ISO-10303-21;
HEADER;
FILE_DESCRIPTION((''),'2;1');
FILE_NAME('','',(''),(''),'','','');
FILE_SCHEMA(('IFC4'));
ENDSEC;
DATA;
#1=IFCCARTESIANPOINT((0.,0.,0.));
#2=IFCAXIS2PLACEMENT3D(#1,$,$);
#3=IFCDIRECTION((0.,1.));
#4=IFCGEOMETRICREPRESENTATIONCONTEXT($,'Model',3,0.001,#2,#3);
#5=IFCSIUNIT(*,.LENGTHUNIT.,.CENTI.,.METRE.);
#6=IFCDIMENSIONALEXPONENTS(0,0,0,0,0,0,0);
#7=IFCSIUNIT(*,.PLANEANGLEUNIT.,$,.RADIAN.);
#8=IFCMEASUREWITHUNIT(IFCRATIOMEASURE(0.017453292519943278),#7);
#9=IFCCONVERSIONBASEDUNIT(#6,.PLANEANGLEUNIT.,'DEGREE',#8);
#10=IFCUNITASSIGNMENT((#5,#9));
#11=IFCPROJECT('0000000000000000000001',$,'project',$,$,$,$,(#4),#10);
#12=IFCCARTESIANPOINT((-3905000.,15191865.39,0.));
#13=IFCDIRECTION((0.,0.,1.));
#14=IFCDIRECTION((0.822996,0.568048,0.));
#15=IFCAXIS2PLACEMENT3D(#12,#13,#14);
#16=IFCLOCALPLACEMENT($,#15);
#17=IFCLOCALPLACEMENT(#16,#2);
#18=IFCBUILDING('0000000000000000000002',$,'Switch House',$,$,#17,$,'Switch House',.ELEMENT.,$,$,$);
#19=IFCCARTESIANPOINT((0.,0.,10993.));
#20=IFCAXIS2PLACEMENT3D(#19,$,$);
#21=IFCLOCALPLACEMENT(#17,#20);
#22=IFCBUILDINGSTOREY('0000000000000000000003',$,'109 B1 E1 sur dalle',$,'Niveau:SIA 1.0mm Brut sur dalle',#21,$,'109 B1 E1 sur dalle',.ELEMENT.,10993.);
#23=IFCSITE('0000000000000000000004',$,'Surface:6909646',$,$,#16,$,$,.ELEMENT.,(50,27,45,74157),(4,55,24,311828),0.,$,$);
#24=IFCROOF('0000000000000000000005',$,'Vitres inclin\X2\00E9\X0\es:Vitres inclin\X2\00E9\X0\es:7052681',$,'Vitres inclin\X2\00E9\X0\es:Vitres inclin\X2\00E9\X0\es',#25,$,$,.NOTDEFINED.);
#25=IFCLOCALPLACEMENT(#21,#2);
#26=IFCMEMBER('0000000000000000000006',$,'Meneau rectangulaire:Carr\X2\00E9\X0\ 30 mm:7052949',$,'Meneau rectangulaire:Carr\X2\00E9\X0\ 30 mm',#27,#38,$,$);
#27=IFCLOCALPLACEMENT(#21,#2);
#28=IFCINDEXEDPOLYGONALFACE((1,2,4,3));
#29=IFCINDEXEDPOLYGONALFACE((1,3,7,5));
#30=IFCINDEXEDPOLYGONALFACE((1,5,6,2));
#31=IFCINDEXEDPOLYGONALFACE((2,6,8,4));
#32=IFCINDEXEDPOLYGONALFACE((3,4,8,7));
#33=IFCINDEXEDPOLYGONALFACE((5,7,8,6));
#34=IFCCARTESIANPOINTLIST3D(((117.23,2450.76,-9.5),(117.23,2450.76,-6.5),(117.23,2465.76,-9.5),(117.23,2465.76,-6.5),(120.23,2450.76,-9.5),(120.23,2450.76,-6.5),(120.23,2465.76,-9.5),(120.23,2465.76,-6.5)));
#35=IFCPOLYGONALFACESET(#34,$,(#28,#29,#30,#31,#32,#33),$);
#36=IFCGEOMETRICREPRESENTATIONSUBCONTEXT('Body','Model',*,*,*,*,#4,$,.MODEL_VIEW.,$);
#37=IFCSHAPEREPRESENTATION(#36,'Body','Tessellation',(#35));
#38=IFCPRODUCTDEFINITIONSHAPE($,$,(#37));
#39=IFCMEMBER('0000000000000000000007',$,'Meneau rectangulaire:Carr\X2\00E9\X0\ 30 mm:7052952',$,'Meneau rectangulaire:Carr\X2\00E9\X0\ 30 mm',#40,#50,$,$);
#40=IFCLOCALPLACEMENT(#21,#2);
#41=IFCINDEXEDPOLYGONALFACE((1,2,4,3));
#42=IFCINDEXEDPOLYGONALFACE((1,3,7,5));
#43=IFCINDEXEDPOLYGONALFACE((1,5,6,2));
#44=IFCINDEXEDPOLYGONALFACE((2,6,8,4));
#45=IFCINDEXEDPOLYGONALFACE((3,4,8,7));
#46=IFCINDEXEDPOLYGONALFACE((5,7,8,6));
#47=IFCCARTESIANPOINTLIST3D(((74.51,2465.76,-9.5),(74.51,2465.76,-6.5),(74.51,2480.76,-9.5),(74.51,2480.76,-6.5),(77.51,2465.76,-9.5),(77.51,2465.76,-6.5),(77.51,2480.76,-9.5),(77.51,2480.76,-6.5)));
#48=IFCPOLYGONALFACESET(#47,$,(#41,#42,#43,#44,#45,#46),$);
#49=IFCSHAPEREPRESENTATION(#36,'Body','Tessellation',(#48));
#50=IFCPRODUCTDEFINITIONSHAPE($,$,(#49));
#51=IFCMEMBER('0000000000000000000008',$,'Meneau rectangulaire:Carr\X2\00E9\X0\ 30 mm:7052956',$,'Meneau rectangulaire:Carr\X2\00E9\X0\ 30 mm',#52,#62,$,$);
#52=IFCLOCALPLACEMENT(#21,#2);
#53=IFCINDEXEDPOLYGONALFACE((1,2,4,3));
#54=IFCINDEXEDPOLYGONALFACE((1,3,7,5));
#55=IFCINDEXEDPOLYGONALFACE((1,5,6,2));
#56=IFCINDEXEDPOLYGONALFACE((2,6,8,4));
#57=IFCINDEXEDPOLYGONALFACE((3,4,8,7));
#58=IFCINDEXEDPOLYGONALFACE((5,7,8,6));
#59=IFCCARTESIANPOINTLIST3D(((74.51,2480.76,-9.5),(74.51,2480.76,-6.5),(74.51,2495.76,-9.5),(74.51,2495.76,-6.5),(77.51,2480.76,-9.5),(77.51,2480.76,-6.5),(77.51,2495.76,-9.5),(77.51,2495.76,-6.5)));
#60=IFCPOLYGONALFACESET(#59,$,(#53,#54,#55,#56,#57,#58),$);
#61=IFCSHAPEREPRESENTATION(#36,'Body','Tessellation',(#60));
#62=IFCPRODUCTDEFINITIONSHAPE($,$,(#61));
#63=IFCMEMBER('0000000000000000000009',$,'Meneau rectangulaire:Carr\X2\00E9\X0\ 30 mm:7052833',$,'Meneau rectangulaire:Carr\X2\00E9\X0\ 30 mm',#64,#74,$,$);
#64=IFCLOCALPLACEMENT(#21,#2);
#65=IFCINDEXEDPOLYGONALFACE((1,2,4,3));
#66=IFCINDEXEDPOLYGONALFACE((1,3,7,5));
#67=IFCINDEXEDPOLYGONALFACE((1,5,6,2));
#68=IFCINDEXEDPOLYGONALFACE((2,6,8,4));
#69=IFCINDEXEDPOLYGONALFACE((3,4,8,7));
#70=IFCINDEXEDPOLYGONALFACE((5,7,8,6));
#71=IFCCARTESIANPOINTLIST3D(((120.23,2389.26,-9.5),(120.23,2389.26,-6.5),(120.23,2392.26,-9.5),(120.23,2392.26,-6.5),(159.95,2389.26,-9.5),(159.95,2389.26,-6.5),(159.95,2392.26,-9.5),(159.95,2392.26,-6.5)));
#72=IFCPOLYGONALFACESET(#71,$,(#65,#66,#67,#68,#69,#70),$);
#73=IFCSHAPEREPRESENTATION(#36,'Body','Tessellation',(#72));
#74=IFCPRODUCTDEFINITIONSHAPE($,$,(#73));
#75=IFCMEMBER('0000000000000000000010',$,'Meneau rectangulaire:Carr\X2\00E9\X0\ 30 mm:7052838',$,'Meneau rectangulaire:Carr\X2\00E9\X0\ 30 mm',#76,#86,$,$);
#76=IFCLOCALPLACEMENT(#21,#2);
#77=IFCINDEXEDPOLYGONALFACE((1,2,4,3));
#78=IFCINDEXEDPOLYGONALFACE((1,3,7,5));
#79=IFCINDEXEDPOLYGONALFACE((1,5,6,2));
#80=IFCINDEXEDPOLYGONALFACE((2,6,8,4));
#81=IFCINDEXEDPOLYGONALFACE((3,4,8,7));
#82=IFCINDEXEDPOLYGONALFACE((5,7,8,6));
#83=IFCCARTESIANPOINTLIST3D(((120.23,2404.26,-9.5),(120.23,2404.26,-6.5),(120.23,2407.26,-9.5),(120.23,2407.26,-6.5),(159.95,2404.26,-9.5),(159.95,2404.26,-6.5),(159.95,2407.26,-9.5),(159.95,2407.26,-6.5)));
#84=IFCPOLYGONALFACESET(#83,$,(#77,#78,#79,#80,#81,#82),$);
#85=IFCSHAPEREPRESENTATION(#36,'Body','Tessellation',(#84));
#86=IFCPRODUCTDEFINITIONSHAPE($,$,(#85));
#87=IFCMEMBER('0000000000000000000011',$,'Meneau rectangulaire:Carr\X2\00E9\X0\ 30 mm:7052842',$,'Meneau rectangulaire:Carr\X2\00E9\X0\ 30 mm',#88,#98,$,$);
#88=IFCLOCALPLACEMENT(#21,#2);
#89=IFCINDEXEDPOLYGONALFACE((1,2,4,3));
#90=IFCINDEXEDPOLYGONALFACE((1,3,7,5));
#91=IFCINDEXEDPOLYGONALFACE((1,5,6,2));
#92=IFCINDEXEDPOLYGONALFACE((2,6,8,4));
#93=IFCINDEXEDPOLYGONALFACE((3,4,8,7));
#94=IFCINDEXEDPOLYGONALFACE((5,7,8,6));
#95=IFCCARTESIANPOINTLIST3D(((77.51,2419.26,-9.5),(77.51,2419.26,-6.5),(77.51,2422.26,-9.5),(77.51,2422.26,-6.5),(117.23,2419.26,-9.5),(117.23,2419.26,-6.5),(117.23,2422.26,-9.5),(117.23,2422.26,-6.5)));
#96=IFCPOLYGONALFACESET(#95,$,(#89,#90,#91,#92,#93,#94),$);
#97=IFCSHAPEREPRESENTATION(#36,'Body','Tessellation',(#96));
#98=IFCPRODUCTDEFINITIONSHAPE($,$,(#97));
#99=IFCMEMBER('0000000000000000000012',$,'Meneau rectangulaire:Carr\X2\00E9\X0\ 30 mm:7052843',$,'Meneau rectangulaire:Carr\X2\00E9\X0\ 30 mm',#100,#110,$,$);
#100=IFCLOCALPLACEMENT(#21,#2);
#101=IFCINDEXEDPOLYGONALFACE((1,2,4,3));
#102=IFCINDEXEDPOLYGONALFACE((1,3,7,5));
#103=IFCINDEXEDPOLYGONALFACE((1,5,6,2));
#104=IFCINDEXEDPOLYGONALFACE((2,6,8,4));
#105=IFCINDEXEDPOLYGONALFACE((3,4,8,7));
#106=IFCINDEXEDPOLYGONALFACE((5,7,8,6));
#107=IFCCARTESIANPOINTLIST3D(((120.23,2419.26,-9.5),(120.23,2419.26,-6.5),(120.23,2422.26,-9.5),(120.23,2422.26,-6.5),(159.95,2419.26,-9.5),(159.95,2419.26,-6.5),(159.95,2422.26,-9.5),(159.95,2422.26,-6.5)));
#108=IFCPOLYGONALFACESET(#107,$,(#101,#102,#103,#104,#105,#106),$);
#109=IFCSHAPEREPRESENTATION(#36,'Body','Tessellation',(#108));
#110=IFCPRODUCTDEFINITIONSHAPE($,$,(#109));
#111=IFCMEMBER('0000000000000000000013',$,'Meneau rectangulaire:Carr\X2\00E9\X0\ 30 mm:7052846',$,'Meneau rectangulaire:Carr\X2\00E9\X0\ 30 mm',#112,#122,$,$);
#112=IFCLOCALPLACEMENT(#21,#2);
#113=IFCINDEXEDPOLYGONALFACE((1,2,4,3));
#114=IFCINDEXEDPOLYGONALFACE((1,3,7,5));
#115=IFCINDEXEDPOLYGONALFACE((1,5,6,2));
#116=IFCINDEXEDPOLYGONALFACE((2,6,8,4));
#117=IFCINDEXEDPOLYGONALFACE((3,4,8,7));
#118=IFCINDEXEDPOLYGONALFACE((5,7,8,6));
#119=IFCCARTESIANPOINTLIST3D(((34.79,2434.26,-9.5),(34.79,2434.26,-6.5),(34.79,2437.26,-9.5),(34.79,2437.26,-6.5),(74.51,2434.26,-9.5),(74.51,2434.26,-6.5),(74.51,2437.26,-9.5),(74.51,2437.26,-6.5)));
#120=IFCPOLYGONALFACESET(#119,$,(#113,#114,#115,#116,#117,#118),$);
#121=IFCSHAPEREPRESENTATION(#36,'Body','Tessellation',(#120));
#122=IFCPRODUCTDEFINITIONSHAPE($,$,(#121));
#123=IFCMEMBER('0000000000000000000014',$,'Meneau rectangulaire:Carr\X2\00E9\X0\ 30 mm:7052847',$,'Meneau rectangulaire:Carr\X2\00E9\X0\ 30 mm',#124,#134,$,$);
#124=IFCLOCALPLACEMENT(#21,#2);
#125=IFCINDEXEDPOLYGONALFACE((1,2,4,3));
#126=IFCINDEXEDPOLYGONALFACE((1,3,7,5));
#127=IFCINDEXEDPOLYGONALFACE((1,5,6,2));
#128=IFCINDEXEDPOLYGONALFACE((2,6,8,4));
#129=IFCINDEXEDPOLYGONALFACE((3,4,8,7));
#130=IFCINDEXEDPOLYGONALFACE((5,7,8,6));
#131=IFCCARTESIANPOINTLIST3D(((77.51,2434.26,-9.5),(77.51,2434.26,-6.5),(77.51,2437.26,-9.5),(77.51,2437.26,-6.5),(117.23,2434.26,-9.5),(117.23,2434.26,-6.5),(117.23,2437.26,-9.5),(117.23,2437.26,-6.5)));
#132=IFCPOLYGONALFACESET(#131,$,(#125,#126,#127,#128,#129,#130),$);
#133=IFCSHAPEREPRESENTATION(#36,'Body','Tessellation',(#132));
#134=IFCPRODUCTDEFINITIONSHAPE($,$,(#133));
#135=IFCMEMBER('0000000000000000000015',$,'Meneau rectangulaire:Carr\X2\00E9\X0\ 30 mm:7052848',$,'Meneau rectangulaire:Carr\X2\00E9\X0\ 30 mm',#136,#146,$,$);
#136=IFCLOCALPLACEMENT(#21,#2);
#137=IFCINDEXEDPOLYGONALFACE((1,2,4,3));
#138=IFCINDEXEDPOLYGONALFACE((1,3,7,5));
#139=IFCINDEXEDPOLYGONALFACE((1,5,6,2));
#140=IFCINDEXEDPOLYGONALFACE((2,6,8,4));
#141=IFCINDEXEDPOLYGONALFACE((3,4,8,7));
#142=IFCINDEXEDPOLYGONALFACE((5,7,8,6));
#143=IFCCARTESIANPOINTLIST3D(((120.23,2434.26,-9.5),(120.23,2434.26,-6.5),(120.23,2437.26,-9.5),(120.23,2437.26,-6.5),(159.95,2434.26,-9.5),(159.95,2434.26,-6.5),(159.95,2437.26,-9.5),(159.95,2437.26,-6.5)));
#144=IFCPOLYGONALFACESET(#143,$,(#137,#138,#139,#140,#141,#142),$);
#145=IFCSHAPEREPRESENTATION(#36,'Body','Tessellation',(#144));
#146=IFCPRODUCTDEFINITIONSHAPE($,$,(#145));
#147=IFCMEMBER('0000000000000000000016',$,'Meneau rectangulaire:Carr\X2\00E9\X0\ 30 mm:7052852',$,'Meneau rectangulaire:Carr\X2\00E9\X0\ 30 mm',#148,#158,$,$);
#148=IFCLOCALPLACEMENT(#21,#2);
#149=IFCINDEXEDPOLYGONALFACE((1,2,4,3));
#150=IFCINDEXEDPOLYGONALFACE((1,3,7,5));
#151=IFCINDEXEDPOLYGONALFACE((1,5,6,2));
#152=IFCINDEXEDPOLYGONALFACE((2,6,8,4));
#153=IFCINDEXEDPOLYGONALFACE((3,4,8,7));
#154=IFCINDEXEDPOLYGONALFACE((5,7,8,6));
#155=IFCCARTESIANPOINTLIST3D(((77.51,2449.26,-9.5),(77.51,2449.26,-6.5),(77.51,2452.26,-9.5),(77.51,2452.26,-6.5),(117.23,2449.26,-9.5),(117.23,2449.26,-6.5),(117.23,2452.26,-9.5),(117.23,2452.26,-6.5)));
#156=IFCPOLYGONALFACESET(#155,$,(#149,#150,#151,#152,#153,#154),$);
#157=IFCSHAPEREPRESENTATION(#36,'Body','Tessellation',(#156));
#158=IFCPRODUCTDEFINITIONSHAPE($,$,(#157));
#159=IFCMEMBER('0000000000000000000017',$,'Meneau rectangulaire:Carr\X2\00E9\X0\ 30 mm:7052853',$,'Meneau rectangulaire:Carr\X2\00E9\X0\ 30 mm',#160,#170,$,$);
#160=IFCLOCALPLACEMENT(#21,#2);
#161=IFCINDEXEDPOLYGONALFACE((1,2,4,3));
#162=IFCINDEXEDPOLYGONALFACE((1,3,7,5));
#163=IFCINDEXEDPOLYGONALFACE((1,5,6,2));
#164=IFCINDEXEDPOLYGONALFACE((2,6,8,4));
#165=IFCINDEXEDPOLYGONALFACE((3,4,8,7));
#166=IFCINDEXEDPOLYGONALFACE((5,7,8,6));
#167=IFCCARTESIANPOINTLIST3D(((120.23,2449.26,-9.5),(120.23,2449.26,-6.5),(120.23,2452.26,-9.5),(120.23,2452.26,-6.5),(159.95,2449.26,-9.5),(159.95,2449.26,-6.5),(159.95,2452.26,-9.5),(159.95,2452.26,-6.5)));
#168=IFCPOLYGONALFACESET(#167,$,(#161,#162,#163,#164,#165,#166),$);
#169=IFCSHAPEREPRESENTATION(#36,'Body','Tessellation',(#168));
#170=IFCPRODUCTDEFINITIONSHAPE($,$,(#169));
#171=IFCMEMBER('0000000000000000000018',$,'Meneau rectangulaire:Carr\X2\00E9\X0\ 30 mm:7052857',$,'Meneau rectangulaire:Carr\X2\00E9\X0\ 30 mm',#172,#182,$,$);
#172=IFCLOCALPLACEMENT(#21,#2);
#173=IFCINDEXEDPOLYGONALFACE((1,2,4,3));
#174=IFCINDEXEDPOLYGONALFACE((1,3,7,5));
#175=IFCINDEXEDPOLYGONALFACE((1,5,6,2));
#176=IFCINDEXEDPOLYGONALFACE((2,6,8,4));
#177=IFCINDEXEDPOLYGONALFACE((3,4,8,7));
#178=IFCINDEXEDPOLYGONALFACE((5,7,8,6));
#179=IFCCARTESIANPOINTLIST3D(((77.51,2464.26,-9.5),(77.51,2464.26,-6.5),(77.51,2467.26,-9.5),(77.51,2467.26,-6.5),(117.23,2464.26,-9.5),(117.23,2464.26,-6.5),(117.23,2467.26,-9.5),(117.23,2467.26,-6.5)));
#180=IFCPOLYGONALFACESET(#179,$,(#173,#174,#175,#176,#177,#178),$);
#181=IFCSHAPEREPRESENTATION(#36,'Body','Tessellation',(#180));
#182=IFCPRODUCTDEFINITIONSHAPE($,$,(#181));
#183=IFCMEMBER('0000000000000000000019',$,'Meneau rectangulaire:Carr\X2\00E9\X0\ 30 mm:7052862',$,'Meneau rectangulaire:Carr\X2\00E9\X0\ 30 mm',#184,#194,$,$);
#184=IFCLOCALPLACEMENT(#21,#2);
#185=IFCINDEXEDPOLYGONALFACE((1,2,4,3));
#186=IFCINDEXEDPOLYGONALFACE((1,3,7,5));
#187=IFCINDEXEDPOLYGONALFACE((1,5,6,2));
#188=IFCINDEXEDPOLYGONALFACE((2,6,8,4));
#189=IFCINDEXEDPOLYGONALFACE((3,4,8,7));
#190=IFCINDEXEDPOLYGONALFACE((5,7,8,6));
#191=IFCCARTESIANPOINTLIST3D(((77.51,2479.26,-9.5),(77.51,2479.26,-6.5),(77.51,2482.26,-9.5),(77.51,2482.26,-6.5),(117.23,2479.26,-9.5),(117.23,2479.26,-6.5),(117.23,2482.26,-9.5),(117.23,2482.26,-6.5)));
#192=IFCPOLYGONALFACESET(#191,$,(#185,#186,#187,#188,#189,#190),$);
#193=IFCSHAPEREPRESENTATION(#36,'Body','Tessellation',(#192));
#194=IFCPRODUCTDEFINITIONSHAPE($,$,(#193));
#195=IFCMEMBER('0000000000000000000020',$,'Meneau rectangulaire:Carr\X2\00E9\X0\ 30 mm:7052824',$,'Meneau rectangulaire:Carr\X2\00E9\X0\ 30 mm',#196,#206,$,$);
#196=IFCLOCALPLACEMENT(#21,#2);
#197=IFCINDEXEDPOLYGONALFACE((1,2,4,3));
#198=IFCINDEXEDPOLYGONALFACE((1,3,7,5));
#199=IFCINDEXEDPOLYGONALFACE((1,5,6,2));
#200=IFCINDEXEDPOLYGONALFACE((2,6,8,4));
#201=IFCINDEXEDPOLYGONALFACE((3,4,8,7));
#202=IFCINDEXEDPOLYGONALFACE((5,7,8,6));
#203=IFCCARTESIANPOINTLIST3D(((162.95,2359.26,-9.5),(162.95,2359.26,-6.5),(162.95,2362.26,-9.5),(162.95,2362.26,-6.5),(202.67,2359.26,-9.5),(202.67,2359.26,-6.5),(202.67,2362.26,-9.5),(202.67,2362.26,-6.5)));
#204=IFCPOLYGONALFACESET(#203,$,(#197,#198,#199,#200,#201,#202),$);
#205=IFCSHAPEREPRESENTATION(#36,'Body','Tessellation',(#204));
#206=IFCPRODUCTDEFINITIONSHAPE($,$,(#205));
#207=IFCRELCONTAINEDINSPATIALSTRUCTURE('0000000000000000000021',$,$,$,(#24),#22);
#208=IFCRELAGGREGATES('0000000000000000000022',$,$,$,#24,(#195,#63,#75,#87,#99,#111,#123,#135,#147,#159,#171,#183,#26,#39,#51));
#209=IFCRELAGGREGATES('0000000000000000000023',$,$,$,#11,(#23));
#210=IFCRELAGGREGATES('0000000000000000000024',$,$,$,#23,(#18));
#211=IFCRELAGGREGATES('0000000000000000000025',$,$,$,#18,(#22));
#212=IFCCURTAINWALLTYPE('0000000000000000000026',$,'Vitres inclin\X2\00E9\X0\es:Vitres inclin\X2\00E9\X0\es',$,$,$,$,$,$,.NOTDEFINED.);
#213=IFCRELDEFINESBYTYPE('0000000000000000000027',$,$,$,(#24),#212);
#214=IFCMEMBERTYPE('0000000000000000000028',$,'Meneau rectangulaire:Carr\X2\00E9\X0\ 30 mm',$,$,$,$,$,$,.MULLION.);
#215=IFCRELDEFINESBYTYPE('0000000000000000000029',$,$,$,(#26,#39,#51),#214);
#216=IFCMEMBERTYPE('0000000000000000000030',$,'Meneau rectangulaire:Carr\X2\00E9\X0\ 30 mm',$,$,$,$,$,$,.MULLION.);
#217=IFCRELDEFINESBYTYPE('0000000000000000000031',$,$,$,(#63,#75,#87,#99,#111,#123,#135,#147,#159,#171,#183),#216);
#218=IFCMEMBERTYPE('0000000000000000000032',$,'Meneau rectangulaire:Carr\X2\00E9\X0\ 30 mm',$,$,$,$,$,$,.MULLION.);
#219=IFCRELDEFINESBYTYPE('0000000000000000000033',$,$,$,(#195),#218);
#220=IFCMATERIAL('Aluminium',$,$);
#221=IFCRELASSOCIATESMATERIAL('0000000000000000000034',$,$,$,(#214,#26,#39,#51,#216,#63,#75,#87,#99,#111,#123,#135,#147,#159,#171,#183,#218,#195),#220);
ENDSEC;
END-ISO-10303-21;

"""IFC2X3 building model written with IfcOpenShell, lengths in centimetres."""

from ifc_helpers import new_model, entity, si_unit, converted_unit, direction, frame, origin, origin_2d_with_axis, place, context, subcontext, project, spatial, rectangle, extrude, source, transform, mapped, material, type_object, type_shapes, element, aggregate, save


model = new_model("IFC2X3")

# Units and contexts
model_context = context("Model", 3, precision=0.001, world=origin(), true_north=direction((0.0, 1.0)))
body_context = subcontext(model_context, "Body", "Model", "MODEL_VIEW")
ifc_project = project(units=[si_unit("LENGTHUNIT", "METRE", prefix="CENTI"), converted_unit("PLANEANGLEUNIT", "DEGREE", entity("IfcRatioMeasure", 0.017453292519943278), si_unit("PLANEANGLEUNIT", "RADIAN"), dimensions=[0, 0, 0, 0, 0, 0, 0])], contexts=[model_context])

# Site, building, storey
site_placement = place(None, frame((-3905000.0, 15191865.39, 0.0), z_axis=(0.0, 0.0, 1.0), x_axis=(0.822996, 0.568048, 0.0)))
site = spatial("IfcSite", under=ifc_project, at=site_placement, Name="Surface:6909646", CompositionType="ELEMENT", RefLatitude=(50, 27, 45, 74157), RefLongitude=(4, 55, 24, 311828), RefElevation=0.0)
building_placement = place(site_placement, origin())
building = spatial("IfcBuilding", under=site, at=building_placement, Name="Switch House", LongName="Switch House", CompositionType="ELEMENT")
storey_placement = place(building_placement, frame((0.0, 0.0, 10993.0)))
storey = spatial("IfcBuildingStorey", under=building, at=storey_placement, Name="109 B1 E1 sur dalle", ObjectType="Niveau:SIA 1.0mm Brut sur dalle", LongName="109 B1 E1 sur dalle", CompositionType="ELEMENT", Elevation=10993.0)

# Roof, members
curtain_wall_type = type_object("IfcCurtainWallType", Name="Vitres inclinées:Vitres inclinées", PredefinedType="NOTDEFINED")
roof_placement = place(storey_placement, frame((0.0, 0.0, -10993.0)))
roof = element("IfcRoof", 1, at=roof_placement, inside=storey, type_object=curtain_wall_type, Name="Vitres inclinées:Vitres inclinées:7052681", ObjectType="Vitres inclinées:Vitres inclinées", ShapeType="NOTDEFINED")
ifc_material = material(Name="Aluminium")
member_type_1 = type_object("IfcMemberType", Name="Meneau rectangulaire:Carré 30 mm", PredefinedType="MULLION", material=ifc_material)
shared_shape_1 = source(origin(), body_context, "Body", "SweptSolid", [
    extrude(rectangle(XDim=3.0, YDim=3.0, at=origin_2d_with_axis()), frame((0.0, 0.0, -15.0), z_axis=(0.0, 0.0, 1.0), x_axis=(0.0, -1.0, 0.0)), (0.0, 0.0, 1.0), 15.0),
])
type_shapes(member_type_1, [shared_shape_1])
member_1_placement = place(roof_placement, frame((118.73, 2465.76, 10985.0), z_axis=(0.0, 1.0, 0.0), x_axis=(1.0, 0.0, 0.0)))
member_1 = element("IfcMember", 2, at=member_1_placement, type_object=member_type_1, material=ifc_material, Name="Meneau rectangulaire:Carré 30 mm:7052949", ObjectType="Meneau rectangulaire:Carré 30 mm", context=body_context, shape_type="MappedRepresentation", body=[
    mapped(shared_shape_1, transform((0.0, 0.0, 0.0), scale=1.0)),
])
member_2_placement = place(roof_placement, frame((76.01, 2480.76, 10985.0), z_axis=(0.0, 1.0, 0.0), x_axis=(1.0, 0.0, 0.0)))
member_2 = element("IfcMember", 3, at=member_2_placement, type_object=member_type_1, material=ifc_material, Name="Meneau rectangulaire:Carré 30 mm:7052952", ObjectType="Meneau rectangulaire:Carré 30 mm", context=body_context, shape_type="MappedRepresentation", body=[
    mapped(shared_shape_1, transform((0.0, 0.0, 0.0), scale=1.0)),
])
member_3_placement = place(roof_placement, frame((76.01, 2495.76, 10985.0), z_axis=(0.0, 1.0, 0.0), x_axis=(1.0, 0.0, 0.0)))
member_3 = element("IfcMember", 4, at=member_3_placement, type_object=member_type_1, material=ifc_material, Name="Meneau rectangulaire:Carré 30 mm:7052956", ObjectType="Meneau rectangulaire:Carré 30 mm", context=body_context, shape_type="MappedRepresentation", body=[
    mapped(shared_shape_1, transform((0.0, 0.0, 0.0), scale=1.0)),
])
member_type_2 = type_object("IfcMemberType", Name="Meneau rectangulaire:Carré 30 mm", PredefinedType="MULLION", material=ifc_material)
shared_shape_2 = source(origin(), body_context, "Body", "SweptSolid", [
    extrude(rectangle(XDim=3.0, YDim=3.0, at=origin_2d_with_axis()), frame((0.0, 0.0, -39.72), z_axis=(0.0, 0.0, 1.0), x_axis=(0.0, -1.0, 0.0)), (0.0, 0.0, 1.0), 39.72),
])
type_shapes(member_type_2, [shared_shape_2])
member_4_placement = place(roof_placement, frame((120.23, 2390.76, 10985.0), z_axis=(-1.0, 0.0, 0.0), x_axis=(0.0, 1.0, 0.0)))
member_4 = element("IfcMember", 5, at=member_4_placement, type_object=member_type_2, material=ifc_material, Name="Meneau rectangulaire:Carré 30 mm:7052833", ObjectType="Meneau rectangulaire:Carré 30 mm", context=body_context, shape_type="MappedRepresentation", body=[
    mapped(shared_shape_2, transform((0.0, 0.0, 0.0), scale=1.0)),
])
member_5_placement = place(roof_placement, frame((120.23, 2405.76, 10985.0), z_axis=(-1.0, 0.0, 0.0), x_axis=(0.0, 1.0, 0.0)))
member_5 = element("IfcMember", 6, at=member_5_placement, type_object=member_type_2, material=ifc_material, Name="Meneau rectangulaire:Carré 30 mm:7052838", ObjectType="Meneau rectangulaire:Carré 30 mm", context=body_context, shape_type="MappedRepresentation", body=[
    mapped(shared_shape_2, transform((0.0, 0.0, 0.0), scale=1.0)),
])
member_6_placement = place(roof_placement, frame((77.51, 2420.76, 10985.0), z_axis=(-1.0, 0.0, 0.0), x_axis=(0.0, 1.0, 0.0)))
member_6 = element("IfcMember", 7, at=member_6_placement, type_object=member_type_2, material=ifc_material, Name="Meneau rectangulaire:Carré 30 mm:7052842", ObjectType="Meneau rectangulaire:Carré 30 mm", context=body_context, shape_type="MappedRepresentation", body=[
    mapped(shared_shape_2, transform((0.0, 0.0, 0.0), scale=1.0)),
])
member_7_placement = place(roof_placement, frame((120.23, 2420.76, 10985.0), z_axis=(-1.0, 0.0, 0.0), x_axis=(0.0, 1.0, 0.0)))
member_7 = element("IfcMember", 8, at=member_7_placement, type_object=member_type_2, material=ifc_material, Name="Meneau rectangulaire:Carré 30 mm:7052843", ObjectType="Meneau rectangulaire:Carré 30 mm", context=body_context, shape_type="MappedRepresentation", body=[
    mapped(shared_shape_2, transform((0.0, 0.0, 0.0), scale=1.0)),
])
member_8_placement = place(roof_placement, frame((34.79, 2435.76, 10985.0), z_axis=(-1.0, 0.0, 0.0), x_axis=(0.0, 1.0, 0.0)))
member_8 = element("IfcMember", 9, at=member_8_placement, type_object=member_type_2, material=ifc_material, Name="Meneau rectangulaire:Carré 30 mm:7052846", ObjectType="Meneau rectangulaire:Carré 30 mm", context=body_context, shape_type="MappedRepresentation", body=[
    mapped(shared_shape_2, transform((0.0, 0.0, 0.0), scale=1.0)),
])
member_9_placement = place(roof_placement, frame((77.51, 2435.76, 10985.0), z_axis=(-1.0, 0.0, 0.0), x_axis=(0.0, 1.0, 0.0)))
member_9 = element("IfcMember", 10, at=member_9_placement, type_object=member_type_2, material=ifc_material, Name="Meneau rectangulaire:Carré 30 mm:7052847", ObjectType="Meneau rectangulaire:Carré 30 mm", context=body_context, shape_type="MappedRepresentation", body=[
    mapped(shared_shape_2, transform((0.0, 0.0, 0.0), scale=1.0)),
])
member_10_placement = place(roof_placement, frame((120.23, 2435.76, 10985.0), z_axis=(-1.0, 0.0, 0.0), x_axis=(0.0, 1.0, 0.0)))
member_10 = element("IfcMember", 11, at=member_10_placement, type_object=member_type_2, material=ifc_material, Name="Meneau rectangulaire:Carré 30 mm:7052848", ObjectType="Meneau rectangulaire:Carré 30 mm", context=body_context, shape_type="MappedRepresentation", body=[
    mapped(shared_shape_2, transform((0.0, 0.0, 0.0), scale=1.0)),
])
member_11_placement = place(roof_placement, frame((77.51, 2450.76, 10985.0), z_axis=(-1.0, 0.0, 0.0), x_axis=(0.0, 1.0, 0.0)))
member_11 = element("IfcMember", 12, at=member_11_placement, type_object=member_type_2, material=ifc_material, Name="Meneau rectangulaire:Carré 30 mm:7052852", ObjectType="Meneau rectangulaire:Carré 30 mm", context=body_context, shape_type="MappedRepresentation", body=[
    mapped(shared_shape_2, transform((0.0, 0.0, 0.0), scale=1.0)),
])
member_12_placement = place(roof_placement, frame((120.23, 2450.76, 10985.0), z_axis=(-1.0, 0.0, 0.0), x_axis=(0.0, 1.0, 0.0)))
member_12 = element("IfcMember", 13, at=member_12_placement, type_object=member_type_2, material=ifc_material, Name="Meneau rectangulaire:Carré 30 mm:7052853", ObjectType="Meneau rectangulaire:Carré 30 mm", context=body_context, shape_type="MappedRepresentation", body=[
    mapped(shared_shape_2, transform((0.0, 0.0, 0.0), scale=1.0)),
])
member_13_placement = place(roof_placement, frame((77.51, 2465.76, 10985.0), z_axis=(-1.0, 0.0, 0.0), x_axis=(0.0, 1.0, 0.0)))
member_13 = element("IfcMember", 14, at=member_13_placement, type_object=member_type_2, material=ifc_material, Name="Meneau rectangulaire:Carré 30 mm:7052857", ObjectType="Meneau rectangulaire:Carré 30 mm", context=body_context, shape_type="MappedRepresentation", body=[
    mapped(shared_shape_2, transform((0.0, 0.0, 0.0), scale=1.0)),
])
member_14_placement = place(roof_placement, frame((77.51, 2480.76, 10985.0), z_axis=(-1.0, 0.0, 0.0), x_axis=(0.0, 1.0, 0.0)))
member_14 = element("IfcMember", 15, at=member_14_placement, type_object=member_type_2, material=ifc_material, Name="Meneau rectangulaire:Carré 30 mm:7052862", ObjectType="Meneau rectangulaire:Carré 30 mm", context=body_context, shape_type="MappedRepresentation", body=[
    mapped(shared_shape_2, transform((0.0, 0.0, 0.0), scale=1.0)),
])
member_type_3 = type_object("IfcMemberType", Name="Meneau rectangulaire:Carré 30 mm", PredefinedType="MULLION", material=ifc_material)
shared_shape_3 = source(origin(), body_context, "Body", "SweptSolid", [
    extrude(rectangle(XDim=3.0, YDim=3.0, at=origin_2d_with_axis()), frame((0.0, 0.0, -39.72), z_axis=(0.0, 0.0, 1.0), x_axis=(0.0, -1.0, 0.0)), (0.0, 0.0, 1.0), 39.72),
])
type_shapes(member_type_3, [shared_shape_3])
member_15_placement = place(roof_placement, frame((162.95, 2360.76, 10985.0), z_axis=(-1.0, 0.0, 0.0), x_axis=(0.0, 1.0, 0.0)))
member_15 = element("IfcMember", 16, at=member_15_placement, type_object=member_type_3, material=ifc_material, Name="Meneau rectangulaire:Carré 30 mm:7052824", ObjectType="Meneau rectangulaire:Carré 30 mm", context=body_context, shape_type="MappedRepresentation", body=[
    mapped(shared_shape_3, transform((0.0, 0.0, 0.0), scale=1.0)),
])
aggregate(roof, [member_15, member_4, member_5, member_6, member_7, member_8, member_9, member_10, member_11, member_12, member_13, member_14, member_1, member_2, member_3])

save(model, "model.ifc")
